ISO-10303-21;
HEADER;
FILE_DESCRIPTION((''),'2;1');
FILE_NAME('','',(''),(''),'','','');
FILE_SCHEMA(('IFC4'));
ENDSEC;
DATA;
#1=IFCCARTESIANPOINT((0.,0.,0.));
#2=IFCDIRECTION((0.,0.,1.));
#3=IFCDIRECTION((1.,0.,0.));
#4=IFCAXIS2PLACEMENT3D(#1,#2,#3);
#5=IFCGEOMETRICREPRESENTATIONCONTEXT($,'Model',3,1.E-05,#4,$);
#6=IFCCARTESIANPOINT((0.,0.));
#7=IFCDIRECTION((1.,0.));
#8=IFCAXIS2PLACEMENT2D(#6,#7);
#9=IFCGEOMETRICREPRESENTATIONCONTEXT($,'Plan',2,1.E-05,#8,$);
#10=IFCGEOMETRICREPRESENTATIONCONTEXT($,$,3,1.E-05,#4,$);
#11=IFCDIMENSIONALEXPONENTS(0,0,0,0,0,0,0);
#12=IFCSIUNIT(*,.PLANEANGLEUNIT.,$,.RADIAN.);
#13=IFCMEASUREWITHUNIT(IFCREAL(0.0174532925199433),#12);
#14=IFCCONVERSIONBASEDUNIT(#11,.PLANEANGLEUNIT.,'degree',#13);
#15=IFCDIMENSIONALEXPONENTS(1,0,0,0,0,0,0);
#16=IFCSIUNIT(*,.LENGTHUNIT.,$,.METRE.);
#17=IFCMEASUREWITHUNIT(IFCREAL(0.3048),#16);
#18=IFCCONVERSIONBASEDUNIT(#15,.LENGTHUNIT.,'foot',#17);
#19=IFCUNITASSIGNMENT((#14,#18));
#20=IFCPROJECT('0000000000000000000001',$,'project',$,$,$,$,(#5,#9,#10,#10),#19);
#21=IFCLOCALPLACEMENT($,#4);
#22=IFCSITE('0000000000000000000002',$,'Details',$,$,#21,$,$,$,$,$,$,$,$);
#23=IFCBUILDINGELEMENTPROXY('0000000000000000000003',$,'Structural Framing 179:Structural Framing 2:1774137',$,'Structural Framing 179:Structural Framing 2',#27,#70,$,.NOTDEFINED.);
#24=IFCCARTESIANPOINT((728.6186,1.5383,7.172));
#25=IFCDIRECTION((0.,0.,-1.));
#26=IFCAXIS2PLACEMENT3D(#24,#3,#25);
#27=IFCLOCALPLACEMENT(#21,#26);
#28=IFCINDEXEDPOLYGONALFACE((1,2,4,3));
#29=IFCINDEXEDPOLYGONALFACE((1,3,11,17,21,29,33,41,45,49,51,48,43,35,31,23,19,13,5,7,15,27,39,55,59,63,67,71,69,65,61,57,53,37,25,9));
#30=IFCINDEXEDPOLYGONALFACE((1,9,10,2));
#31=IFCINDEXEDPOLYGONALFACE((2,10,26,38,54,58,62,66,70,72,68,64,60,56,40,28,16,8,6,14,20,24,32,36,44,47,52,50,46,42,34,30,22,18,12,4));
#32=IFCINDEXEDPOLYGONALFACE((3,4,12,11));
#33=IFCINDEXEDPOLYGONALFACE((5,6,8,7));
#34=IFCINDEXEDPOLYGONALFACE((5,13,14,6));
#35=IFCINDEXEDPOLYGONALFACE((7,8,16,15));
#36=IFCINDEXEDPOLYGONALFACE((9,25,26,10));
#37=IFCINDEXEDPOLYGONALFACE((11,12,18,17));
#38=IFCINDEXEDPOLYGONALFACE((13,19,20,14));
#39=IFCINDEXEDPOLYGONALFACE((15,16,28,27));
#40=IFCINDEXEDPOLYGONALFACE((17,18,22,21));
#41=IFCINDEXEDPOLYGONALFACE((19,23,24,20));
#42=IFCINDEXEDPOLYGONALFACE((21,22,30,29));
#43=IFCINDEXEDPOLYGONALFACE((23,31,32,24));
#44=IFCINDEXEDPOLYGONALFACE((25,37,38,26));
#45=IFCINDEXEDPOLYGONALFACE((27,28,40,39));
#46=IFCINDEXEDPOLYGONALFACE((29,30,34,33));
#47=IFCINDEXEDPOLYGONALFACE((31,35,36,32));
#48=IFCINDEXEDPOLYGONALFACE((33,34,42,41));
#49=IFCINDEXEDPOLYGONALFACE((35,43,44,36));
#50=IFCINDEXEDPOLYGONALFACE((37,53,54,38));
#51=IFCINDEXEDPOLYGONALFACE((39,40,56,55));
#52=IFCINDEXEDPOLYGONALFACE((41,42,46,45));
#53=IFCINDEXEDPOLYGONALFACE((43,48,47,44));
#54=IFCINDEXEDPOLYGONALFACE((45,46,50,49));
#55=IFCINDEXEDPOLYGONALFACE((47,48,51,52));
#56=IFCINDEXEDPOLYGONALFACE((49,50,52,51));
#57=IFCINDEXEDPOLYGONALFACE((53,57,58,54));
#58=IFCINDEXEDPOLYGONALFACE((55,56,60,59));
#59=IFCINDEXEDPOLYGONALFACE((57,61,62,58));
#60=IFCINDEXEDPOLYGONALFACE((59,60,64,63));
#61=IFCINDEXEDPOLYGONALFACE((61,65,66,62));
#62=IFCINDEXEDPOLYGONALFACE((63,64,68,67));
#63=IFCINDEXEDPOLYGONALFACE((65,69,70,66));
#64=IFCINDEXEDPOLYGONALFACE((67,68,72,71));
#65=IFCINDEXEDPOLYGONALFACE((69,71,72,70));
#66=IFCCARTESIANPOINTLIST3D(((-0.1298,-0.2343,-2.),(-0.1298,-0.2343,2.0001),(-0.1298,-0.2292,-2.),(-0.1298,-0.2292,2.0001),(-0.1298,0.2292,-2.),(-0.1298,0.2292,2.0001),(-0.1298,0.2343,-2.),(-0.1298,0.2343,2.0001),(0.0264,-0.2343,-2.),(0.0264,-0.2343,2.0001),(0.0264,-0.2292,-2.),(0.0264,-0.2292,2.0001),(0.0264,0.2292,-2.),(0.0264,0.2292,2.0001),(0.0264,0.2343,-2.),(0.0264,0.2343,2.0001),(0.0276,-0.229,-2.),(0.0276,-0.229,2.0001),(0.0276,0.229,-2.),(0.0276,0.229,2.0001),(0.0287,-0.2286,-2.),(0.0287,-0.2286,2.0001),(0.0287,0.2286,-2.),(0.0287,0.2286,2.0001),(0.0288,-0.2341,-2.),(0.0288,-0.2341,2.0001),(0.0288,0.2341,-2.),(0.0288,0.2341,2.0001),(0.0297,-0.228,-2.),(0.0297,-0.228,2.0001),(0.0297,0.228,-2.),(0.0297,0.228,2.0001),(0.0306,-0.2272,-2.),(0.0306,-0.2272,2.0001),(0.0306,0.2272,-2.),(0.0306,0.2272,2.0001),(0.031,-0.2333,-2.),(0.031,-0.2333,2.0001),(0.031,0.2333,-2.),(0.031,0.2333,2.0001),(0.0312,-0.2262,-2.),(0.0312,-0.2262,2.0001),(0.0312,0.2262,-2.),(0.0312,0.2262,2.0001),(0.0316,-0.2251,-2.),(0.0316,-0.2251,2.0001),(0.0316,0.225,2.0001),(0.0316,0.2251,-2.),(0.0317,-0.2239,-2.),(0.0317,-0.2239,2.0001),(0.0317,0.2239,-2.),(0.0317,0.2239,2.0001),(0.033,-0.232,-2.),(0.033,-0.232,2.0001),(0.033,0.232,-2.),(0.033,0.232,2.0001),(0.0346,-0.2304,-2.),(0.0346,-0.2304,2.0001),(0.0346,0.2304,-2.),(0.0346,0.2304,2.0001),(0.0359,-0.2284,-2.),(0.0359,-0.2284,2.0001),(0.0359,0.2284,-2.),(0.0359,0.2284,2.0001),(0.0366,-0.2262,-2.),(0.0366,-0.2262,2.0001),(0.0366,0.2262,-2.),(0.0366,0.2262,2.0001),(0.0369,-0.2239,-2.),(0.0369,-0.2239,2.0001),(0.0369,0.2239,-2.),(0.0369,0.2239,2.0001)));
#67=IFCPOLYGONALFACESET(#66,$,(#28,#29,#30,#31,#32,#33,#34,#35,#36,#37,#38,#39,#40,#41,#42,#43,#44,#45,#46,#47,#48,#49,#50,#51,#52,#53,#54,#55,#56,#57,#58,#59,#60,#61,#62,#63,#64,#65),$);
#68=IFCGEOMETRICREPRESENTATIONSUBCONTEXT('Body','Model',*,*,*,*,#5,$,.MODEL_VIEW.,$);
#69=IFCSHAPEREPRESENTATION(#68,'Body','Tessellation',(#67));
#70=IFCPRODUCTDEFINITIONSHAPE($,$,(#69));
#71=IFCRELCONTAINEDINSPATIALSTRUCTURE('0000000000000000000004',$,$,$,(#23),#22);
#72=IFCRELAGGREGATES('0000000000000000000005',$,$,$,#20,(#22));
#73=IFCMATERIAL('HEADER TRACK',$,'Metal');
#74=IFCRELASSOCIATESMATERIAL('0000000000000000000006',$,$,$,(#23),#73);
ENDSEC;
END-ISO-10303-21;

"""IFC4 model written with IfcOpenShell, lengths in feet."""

from ifc_helpers import new_model, entity, si_unit, converted_unit, frame, origin_with_axes, origin_2d_with_axis, place, context, subcontext, project, spatial, polyline, outline, extrude, material, element, save


model = new_model("IFC4")

# Units and contexts
model_context = context("Model", 3, precision=1e-05, world=origin_with_axes())
plan_context = context("Plan", 2, precision=1e-05, world=origin_2d_with_axis())
context_of_model = context(None, 3, precision=1e-05, world=origin_with_axes())
body_context = subcontext(model_context, "Body", "Model", "MODEL_VIEW")
ifc_project = project(units=[converted_unit("PLANEANGLEUNIT", "degree", entity("IfcReal", 0.0174532925199433), si_unit("PLANEANGLEUNIT", "RADIAN"), dimensions=[0, 0, 0, 0, 0, 0, 0]), converted_unit("LENGTHUNIT", "foot", entity("IfcReal", 0.3048), si_unit("LENGTHUNIT", "METRE"), dimensions=[1, 0, 0, 0, 0, 0, 0])], contexts=[model_context, plan_context, context_of_model, context_of_model])

# Site
site_placement = place(None, origin_with_axes())
site = spatial("IfcSite", under=ifc_project, at=site_placement, Name="Details")

# Building element proxy
ifc_material_1 = material(Name="HEADER TRACK", Category="Metal")
proxy_1_placement = place(site_placement, frame((728.6186, 1.5383, 7.172), z_axis=(1.0, 0.0, 0.0), x_axis=(0.0, 0.0, -1.0)))
element("IfcBuildingElementProxy", 1, at=proxy_1_placement, inside=site, material=ifc_material_1, Name="Structural Framing 179:Structural Framing 2:1774137", ObjectType="Structural Framing 179:Structural Framing 2", PredefinedType="NOTDEFINED", context=body_context, shape_type="SweptSolid", body=[
    extrude(outline(polyline([(0.2258, 0.0), (0.2246, -0.0002), (-0.2217, -0.0363), (-0.2229, -0.0363), (-0.224, -0.036), (-0.225, -0.0354), (-0.226, -0.0347), (-0.2267, -0.0337), (-0.2271, -0.0326), (-0.2274, -0.0315), (-0.24, 0.1242), (-0.2451, 0.1238), (-0.2325, -0.0319), (-0.2321, -0.0342), (-0.2311, -0.0363), (-0.2297, -0.0382), (-0.2279, -0.0397), (-0.2259, -0.0408), (-0.2236, -0.0414), (-0.2213, -0.0415), (0.225, -0.0054), (0.2273, -0.0049), (0.2295, -0.004), (0.2313, -0.0026), (0.2329, -0.0008), (0.2339, 0.0013), (0.2345, 0.0036), (0.2346, 0.0059), (0.222, 0.1616), (0.2169, 0.1612), (0.2295, 0.0055), (0.2294, 0.0043), (0.2291, 0.0031), (0.2286, 0.0021), (0.2278, 0.0012), (0.2269, 0.0005), (0.2258, 0.0)])), frame((0.0134, 0.0, -2.0), z_axis=(0.000019, 0.0, -1.0), x_axis=(0.08061, -0.996746, 0.000003)), (0.000003, -0.000019, -1.0), 4.0),
])

save(model, "model.ifc")
